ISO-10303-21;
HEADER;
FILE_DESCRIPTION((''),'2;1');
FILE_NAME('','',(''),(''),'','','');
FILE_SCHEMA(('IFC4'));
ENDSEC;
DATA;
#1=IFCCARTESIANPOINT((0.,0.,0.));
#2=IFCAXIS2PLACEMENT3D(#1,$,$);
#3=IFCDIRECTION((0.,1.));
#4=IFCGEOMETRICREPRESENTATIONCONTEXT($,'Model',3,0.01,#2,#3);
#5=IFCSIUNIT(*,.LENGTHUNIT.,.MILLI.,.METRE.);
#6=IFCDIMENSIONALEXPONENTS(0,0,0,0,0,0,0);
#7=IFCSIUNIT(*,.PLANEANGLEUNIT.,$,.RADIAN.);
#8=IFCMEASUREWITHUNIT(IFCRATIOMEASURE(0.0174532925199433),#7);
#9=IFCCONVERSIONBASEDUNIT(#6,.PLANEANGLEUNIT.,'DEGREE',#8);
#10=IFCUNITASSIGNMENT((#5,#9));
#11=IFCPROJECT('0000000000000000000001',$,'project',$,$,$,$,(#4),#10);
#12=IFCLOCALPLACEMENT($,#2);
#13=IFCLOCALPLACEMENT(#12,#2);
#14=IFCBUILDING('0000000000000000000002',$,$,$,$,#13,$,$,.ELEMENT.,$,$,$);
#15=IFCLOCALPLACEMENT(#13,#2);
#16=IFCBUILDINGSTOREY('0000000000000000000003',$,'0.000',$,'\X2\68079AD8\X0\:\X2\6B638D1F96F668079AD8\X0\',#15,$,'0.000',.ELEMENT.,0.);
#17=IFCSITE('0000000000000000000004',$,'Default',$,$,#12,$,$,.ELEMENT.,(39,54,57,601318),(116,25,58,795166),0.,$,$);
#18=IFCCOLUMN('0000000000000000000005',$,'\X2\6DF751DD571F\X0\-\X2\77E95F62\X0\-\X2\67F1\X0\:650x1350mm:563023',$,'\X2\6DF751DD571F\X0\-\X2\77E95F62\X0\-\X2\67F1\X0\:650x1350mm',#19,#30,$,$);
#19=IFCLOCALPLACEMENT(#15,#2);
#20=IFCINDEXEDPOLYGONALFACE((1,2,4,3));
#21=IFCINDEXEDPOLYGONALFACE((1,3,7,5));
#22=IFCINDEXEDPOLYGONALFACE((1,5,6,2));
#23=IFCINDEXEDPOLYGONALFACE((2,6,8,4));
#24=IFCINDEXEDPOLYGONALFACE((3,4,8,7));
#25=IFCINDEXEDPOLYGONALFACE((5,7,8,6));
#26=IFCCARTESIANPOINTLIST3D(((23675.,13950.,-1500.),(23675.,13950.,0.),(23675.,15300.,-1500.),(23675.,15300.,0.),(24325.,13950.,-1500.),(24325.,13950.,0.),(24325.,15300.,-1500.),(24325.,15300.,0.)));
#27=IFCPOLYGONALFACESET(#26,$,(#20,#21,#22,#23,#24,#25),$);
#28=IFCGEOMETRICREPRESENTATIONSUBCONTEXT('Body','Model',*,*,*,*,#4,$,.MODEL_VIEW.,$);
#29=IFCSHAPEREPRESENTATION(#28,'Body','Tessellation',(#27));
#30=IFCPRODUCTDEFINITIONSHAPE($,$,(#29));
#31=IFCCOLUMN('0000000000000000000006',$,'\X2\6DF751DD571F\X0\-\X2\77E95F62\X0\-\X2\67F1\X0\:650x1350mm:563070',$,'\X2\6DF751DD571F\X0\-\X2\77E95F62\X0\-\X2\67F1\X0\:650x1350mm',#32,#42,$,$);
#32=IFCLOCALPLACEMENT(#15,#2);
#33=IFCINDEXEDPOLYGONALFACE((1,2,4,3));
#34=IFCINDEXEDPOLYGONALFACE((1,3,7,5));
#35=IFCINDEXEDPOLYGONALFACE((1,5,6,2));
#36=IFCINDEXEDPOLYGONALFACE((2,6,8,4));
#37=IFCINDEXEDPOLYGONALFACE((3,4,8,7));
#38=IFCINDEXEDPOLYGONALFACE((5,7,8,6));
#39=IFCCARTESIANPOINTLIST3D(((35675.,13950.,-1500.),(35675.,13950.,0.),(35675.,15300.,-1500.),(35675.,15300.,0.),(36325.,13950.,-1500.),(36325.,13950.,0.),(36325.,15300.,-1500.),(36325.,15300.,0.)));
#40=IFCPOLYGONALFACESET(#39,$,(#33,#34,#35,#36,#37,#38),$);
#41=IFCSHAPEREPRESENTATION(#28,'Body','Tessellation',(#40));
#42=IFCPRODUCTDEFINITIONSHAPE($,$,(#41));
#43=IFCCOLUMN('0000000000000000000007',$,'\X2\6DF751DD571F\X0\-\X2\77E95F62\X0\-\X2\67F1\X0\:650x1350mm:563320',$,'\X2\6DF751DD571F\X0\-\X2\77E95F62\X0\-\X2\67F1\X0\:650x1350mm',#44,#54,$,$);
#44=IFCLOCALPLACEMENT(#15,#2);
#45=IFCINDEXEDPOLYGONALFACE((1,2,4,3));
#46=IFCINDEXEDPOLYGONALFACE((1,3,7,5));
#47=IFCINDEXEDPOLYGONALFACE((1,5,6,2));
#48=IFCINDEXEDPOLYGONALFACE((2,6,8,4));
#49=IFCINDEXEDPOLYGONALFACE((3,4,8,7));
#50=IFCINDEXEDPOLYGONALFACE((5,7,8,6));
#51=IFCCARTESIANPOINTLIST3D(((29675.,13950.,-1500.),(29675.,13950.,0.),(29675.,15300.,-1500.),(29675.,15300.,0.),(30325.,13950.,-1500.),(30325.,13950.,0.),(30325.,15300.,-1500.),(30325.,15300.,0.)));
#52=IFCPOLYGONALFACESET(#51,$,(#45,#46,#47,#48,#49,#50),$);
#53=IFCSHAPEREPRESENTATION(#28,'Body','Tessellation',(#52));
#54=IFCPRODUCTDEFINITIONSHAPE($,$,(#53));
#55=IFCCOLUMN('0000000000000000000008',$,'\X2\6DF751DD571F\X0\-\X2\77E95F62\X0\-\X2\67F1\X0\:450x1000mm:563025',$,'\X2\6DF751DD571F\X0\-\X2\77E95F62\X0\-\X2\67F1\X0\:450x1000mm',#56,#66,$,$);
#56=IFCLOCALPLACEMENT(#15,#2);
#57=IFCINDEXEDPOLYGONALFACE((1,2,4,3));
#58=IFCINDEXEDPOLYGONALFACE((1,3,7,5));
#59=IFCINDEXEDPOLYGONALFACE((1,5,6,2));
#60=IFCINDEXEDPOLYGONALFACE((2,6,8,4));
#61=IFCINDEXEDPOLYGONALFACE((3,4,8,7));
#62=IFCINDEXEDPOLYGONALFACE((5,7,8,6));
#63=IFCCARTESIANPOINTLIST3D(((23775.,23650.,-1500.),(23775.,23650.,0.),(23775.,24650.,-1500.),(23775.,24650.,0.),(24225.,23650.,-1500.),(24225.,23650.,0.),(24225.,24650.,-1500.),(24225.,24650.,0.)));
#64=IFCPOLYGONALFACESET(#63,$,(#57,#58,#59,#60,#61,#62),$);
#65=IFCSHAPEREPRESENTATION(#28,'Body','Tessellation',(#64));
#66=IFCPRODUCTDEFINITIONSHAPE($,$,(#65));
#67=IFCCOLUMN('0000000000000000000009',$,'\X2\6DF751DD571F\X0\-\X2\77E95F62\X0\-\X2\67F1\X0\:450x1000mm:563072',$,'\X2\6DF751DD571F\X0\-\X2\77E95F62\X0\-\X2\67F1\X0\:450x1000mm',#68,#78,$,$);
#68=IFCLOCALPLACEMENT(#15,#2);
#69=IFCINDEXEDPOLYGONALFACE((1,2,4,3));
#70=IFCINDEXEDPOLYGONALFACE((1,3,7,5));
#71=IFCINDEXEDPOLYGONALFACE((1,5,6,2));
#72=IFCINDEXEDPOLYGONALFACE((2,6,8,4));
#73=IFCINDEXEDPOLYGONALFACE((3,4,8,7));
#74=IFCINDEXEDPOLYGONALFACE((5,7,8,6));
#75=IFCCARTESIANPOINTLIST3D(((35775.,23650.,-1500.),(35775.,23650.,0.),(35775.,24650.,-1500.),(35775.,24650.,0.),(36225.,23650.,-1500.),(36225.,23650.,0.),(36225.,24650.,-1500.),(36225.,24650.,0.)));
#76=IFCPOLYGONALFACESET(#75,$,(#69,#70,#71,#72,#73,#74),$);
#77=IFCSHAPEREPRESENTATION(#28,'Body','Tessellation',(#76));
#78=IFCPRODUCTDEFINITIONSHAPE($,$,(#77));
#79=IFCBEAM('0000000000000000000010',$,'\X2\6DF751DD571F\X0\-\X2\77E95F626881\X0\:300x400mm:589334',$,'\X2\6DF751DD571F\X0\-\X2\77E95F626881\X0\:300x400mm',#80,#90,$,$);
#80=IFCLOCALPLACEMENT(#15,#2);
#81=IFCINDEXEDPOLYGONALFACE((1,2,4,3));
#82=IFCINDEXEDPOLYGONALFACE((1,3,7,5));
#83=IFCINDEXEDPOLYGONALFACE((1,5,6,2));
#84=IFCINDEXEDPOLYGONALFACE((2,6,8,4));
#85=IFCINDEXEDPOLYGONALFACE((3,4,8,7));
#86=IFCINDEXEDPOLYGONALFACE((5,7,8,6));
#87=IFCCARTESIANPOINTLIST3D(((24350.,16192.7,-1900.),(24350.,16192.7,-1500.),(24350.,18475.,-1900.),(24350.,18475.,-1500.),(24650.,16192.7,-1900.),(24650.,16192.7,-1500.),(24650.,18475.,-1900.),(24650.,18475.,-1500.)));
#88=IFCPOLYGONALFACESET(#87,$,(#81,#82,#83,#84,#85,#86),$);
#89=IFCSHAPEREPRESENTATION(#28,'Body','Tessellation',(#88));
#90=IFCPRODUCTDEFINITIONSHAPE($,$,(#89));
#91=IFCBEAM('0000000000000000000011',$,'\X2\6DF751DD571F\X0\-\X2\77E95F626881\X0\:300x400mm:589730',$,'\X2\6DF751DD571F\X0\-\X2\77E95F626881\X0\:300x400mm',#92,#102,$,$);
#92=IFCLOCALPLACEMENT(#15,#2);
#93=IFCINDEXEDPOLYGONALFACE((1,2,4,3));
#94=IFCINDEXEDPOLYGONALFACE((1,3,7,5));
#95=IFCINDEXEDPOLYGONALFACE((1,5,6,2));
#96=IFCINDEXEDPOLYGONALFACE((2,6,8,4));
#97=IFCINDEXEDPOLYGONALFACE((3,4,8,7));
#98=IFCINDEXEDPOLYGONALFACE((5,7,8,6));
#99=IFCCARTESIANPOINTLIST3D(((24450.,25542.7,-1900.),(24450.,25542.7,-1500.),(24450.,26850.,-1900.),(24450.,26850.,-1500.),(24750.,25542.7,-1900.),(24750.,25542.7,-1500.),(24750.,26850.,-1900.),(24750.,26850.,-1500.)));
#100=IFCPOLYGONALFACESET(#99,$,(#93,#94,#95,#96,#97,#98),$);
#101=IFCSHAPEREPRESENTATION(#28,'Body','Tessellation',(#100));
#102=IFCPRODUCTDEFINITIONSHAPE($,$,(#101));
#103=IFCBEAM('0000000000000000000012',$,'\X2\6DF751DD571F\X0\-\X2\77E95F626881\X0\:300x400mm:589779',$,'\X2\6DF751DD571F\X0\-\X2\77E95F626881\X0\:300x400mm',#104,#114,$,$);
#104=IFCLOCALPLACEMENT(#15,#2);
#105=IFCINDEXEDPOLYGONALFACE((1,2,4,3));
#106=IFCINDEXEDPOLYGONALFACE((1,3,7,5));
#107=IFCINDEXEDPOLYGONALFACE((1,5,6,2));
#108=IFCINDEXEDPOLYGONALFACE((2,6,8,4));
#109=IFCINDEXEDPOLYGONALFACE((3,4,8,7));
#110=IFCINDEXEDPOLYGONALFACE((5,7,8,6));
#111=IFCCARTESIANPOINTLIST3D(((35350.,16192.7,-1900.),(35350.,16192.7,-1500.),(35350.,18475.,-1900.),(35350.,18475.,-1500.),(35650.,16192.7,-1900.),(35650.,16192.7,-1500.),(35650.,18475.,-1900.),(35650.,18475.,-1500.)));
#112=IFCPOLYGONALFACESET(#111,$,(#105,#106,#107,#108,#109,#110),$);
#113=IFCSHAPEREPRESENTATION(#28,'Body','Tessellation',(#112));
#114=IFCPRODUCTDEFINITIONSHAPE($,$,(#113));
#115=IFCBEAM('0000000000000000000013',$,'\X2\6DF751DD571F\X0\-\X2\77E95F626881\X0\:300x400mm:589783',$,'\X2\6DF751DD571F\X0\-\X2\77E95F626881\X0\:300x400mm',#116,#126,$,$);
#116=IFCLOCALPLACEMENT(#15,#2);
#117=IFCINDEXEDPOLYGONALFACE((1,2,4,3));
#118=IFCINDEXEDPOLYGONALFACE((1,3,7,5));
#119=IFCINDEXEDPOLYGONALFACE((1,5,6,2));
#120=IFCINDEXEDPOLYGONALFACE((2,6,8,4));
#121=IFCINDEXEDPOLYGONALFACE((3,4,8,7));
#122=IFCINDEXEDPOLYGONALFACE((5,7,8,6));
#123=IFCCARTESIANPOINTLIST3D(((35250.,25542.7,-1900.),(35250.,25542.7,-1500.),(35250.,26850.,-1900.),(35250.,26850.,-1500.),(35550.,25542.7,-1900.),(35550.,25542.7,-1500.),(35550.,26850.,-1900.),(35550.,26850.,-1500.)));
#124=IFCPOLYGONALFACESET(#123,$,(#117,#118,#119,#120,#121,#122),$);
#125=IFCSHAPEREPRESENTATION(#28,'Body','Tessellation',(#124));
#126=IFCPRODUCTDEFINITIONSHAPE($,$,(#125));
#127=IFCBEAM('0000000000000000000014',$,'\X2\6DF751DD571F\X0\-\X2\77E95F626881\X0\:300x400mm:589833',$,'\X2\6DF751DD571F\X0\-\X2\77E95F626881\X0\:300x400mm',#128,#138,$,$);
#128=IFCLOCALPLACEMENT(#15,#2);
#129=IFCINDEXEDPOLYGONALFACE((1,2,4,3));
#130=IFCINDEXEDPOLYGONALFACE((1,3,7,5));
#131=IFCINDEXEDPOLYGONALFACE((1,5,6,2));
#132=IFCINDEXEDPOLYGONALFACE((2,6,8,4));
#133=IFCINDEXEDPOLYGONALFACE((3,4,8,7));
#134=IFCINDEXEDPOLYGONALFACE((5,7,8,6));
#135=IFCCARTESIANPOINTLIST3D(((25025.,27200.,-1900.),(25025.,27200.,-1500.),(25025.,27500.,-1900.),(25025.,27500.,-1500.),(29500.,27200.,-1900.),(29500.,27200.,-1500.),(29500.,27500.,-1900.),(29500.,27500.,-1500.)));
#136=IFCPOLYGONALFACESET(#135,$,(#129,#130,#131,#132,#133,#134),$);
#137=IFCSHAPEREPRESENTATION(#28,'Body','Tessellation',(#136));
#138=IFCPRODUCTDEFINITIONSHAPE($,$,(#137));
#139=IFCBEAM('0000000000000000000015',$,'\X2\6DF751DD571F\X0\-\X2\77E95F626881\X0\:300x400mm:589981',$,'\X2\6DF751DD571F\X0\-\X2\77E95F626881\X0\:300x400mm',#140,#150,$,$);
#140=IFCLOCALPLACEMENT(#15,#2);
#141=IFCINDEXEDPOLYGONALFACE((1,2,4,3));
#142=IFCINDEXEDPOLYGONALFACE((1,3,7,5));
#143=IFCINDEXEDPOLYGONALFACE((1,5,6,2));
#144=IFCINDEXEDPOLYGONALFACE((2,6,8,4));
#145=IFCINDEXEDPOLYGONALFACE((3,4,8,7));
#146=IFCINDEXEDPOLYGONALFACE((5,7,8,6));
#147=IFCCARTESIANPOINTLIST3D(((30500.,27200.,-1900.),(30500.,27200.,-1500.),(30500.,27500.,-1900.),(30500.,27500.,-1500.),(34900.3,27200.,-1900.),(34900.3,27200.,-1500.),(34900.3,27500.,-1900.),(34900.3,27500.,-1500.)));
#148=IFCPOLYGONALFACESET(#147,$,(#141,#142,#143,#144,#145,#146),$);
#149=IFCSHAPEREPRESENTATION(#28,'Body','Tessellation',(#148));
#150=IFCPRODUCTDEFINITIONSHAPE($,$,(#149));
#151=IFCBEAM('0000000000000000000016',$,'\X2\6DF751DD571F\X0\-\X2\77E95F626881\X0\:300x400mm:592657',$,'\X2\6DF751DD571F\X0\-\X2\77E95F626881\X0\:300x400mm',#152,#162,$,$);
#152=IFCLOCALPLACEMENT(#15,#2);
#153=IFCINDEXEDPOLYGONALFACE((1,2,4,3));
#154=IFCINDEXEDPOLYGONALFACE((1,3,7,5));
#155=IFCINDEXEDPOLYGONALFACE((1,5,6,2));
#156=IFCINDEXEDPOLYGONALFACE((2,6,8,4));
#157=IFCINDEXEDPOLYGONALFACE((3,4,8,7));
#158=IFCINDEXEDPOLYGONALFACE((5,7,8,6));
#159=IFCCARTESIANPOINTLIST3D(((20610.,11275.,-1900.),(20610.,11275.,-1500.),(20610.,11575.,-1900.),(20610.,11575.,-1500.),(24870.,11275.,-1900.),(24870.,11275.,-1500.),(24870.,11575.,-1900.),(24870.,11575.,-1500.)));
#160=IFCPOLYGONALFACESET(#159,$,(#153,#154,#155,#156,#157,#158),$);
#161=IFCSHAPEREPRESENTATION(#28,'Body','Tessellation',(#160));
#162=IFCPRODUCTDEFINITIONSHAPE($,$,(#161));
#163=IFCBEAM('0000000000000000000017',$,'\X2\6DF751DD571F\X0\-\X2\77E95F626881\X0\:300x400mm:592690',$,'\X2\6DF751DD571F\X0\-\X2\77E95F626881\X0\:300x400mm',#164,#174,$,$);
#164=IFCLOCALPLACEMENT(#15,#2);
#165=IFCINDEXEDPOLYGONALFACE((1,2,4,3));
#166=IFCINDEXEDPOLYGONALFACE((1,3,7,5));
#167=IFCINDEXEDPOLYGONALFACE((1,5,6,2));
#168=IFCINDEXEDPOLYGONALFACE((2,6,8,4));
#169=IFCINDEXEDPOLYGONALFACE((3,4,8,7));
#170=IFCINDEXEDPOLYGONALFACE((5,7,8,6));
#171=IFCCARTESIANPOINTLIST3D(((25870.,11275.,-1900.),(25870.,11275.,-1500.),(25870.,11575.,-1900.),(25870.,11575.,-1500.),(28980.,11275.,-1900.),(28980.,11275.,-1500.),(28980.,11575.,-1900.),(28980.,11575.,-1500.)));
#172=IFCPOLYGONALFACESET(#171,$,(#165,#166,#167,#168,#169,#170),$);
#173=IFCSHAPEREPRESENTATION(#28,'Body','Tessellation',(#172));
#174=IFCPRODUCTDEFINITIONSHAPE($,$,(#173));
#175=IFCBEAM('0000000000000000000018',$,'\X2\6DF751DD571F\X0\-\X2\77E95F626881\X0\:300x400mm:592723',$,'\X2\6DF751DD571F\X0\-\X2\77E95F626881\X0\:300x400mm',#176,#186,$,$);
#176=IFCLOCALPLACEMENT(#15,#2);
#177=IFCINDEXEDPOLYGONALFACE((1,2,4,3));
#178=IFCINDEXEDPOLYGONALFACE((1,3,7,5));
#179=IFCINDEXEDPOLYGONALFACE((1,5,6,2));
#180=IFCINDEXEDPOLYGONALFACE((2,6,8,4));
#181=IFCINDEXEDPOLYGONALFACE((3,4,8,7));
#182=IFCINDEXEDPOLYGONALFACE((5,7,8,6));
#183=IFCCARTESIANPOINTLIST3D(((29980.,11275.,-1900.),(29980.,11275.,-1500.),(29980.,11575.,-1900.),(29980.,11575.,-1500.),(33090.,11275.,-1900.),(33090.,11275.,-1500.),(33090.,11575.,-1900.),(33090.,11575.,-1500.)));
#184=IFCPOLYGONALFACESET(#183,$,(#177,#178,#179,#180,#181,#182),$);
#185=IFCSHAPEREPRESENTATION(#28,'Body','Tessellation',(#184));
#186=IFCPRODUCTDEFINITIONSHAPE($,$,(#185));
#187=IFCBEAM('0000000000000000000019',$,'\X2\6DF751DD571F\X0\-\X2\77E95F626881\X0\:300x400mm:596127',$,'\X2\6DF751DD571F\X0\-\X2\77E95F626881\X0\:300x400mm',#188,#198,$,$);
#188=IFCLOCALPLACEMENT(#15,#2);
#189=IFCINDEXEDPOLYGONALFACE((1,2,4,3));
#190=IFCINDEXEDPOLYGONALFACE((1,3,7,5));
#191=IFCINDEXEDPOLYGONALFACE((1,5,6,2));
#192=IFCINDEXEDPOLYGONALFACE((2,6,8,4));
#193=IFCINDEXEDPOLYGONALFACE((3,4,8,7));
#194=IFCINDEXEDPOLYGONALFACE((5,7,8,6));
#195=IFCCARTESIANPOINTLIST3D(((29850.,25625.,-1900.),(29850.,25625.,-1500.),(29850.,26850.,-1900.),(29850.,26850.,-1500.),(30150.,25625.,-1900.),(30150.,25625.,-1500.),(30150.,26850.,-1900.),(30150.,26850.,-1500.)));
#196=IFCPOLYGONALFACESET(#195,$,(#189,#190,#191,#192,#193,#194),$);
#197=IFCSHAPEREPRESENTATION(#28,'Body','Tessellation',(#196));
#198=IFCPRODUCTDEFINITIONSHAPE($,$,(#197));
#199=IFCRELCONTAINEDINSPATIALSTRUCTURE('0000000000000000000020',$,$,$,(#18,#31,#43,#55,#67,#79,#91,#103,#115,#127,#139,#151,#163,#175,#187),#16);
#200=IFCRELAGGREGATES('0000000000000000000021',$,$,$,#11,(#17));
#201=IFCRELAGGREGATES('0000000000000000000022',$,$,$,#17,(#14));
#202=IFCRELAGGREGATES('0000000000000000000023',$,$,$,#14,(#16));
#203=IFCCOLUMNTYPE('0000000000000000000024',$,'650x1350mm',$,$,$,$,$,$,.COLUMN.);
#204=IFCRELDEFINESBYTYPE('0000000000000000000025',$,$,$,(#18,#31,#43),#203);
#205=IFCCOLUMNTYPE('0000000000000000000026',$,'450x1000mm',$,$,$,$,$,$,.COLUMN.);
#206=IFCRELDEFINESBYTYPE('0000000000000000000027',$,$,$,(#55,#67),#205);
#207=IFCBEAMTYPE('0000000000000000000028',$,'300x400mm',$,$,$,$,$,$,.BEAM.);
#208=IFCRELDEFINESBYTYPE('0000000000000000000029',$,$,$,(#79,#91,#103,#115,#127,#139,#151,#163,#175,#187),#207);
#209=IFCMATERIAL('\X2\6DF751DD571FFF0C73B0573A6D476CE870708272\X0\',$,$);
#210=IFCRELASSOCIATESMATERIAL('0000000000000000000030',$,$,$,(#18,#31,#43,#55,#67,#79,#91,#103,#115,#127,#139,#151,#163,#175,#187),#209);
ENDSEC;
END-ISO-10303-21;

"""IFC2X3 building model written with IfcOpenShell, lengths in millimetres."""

from ifc_helpers import new_model, entity, si_unit, converted_unit, direction, frame, frame_2d, origin, origin_2d_with_axis, place, context, subcontext, project, spatial, rectangle, extrude, source, transform, mapped, material, type_object, type_shapes, element, save


model = new_model("IFC2X3")

# Units and contexts
model_context = context("Model", 3, precision=0.01, world=origin(), true_north=direction((0.0, 1.0)))
body_context = subcontext(model_context, "Body", "Model", "MODEL_VIEW")
ifc_project = project(units=[si_unit("LENGTHUNIT", "METRE", prefix="MILLI"), converted_unit("PLANEANGLEUNIT", "DEGREE", entity("IfcRatioMeasure", 0.0174532925199433), si_unit("PLANEANGLEUNIT", "RADIAN"), dimensions=[0, 0, 0, 0, 0, 0, 0])], contexts=[model_context])

# Site, building, storey
site_placement = place(None, origin())
site = spatial("IfcSite", under=ifc_project, at=site_placement, Name="Default", CompositionType="ELEMENT", RefLatitude=(39, 54, 57, 601318), RefLongitude=(116, 25, 58, 795166), RefElevation=0.0)
building_placement = place(site_placement, origin())
building = spatial("IfcBuilding", under=site, at=building_placement, CompositionType="ELEMENT")
storey_placement = place(building_placement, origin())
storey = spatial("IfcBuildingStorey", under=building, at=storey_placement, Name="0.000", ObjectType="标高:正负零标高", LongName="0.000", CompositionType="ELEMENT", Elevation=0.0)

# Columns
ifc_material = material(Name="混凝土，现场浇注灰色")
column_type_1 = type_object("IfcColumnType", Name="650x1350mm", PredefinedType="COLUMN")
shared_shape_1 = source(origin(), body_context, "Body", "SweptSolid", [
    extrude(rectangle(XDim=1350.0, YDim=650.0, at=origin_2d_with_axis()), frame((0.0, 0.0, -1500.0), z_axis=(0.0, 0.0, 1.0), x_axis=(0.0, -1.0, 0.0)), (0.0, 0.0, 1.0), 1500.0),
])
type_shapes(column_type_1, [shared_shape_1])
for number, where, name in (
    (1, (24000.0, 14625.0, 0.0), "混凝土-矩形-柱:650x1350mm:563023"),
    (2, (36000.0, 14625.0, 0.0), "混凝土-矩形-柱:650x1350mm:563070"),
    (3, (30000.0, 14625.0, 0.0), "混凝土-矩形-柱:650x1350mm:563320"),
):
    element("IfcColumn", number, at=place(storey_placement, frame(where)), inside=storey, type_object=column_type_1, material=ifc_material, Name=name, ObjectType="混凝土-矩形-柱:650x1350mm", context=body_context, shape_type="MappedRepresentation", body=[
        mapped(shared_shape_1, transform((0.0, 0.0, 0.0), scale=1.0)),
    ])
column_type_2 = type_object("IfcColumnType", Name="450x1000mm", PredefinedType="COLUMN")
shared_shape_2 = source(origin(), body_context, "Body", "SweptSolid", [
    extrude(rectangle(XDim=1000.0, YDim=450.0, at=origin_2d_with_axis()), frame((0.0, 0.0, -1500.0), z_axis=(0.0, 0.0, 1.0), x_axis=(0.0, -1.0, 0.0)), (0.0, 0.0, 1.0), 1500.0),
])
type_shapes(column_type_2, [shared_shape_2])
for number, where, name in (
    (4, (24000.0, 24150.0, 0.0), "混凝土-矩形-柱:450x1000mm:563025"),
    (5, (36000.0, 24150.0, 0.0), "混凝土-矩形-柱:450x1000mm:563072"),
):
    element("IfcColumn", number, at=place(storey_placement, frame(where)), inside=storey, type_object=column_type_2, material=ifc_material, Name=name, ObjectType="混凝土-矩形-柱:450x1000mm", context=body_context, shape_type="MappedRepresentation", body=[
        mapped(shared_shape_2, transform((0.0, 0.0, 0.0), scale=1.0)),
    ])

# Beams
beam_type_1 = type_object("IfcBeamType", Name="300x400mm", PredefinedType="BEAM")
beam_1_placement = place(storey_placement, frame((24500.0, 18475.0, -1500.0), z_axis=(0.0, 0.0, 1.0), x_axis=(0.0, -1.0, 0.0)))
element("IfcBeam", 6, at=beam_1_placement, inside=storey, type_object=beam_type_1, material=ifc_material, Name="混凝土-矩形梁:300x400mm:589334", ObjectType="混凝土-矩形梁:300x400mm", context=body_context, shape_type="SweptSolid", body=[
    extrude(rectangle(XDim=400.0, YDim=300.0, at=frame_2d((0.0, 0.0), x_axis=(1.0, 0.0))), frame((0.0, 0.0, -200.0), z_axis=(1.0, 0.0, 0.0), x_axis=(0.0, 0.0, -1.0)), (0.0, 0.0, 1.0), 2282.3),
])
beam_2_placement = place(storey_placement, frame((24600.0, 26850.0, -1500.0), z_axis=(0.0, 0.0, 1.0), x_axis=(0.0, -1.0, 0.0)))
element("IfcBeam", 7, at=beam_2_placement, inside=storey, type_object=beam_type_1, material=ifc_material, Name="混凝土-矩形梁:300x400mm:589730", ObjectType="混凝土-矩形梁:300x400mm", context=body_context, shape_type="SweptSolid", body=[
    extrude(rectangle(XDim=400.0, YDim=300.0, at=frame_2d((0.0, 0.0), x_axis=(1.0, 0.0))), frame((0.0, 0.0, -200.0), z_axis=(1.0, 0.0, 0.0), x_axis=(0.0, 0.0, -1.0)), (0.0, 0.0, 1.0), 1307.3),
])
beam_3_placement = place(storey_placement, frame((35500.0, 18475.0, -1500.0), z_axis=(0.0, 0.0, 1.0), x_axis=(0.0, -1.0, 0.0)))
element("IfcBeam", 8, at=beam_3_placement, inside=storey, type_object=beam_type_1, material=ifc_material, Name="混凝土-矩形梁:300x400mm:589779", ObjectType="混凝土-矩形梁:300x400mm", context=body_context, shape_type="SweptSolid", body=[
    extrude(rectangle(XDim=400.0, YDim=300.0, at=frame_2d((0.0, 0.0), x_axis=(1.0, 0.0))), frame((0.0, 0.0, -200.0), z_axis=(1.0, 0.0, 0.0), x_axis=(0.0, 0.0, -1.0)), (0.0, 0.0, 1.0), 2282.3),
])
beam_4_placement = place(storey_placement, frame((35400.0, 26850.0, -1500.0), z_axis=(0.0, 0.0, 1.0), x_axis=(0.0, -1.0, 0.0)))
element("IfcBeam", 9, at=beam_4_placement, inside=storey, type_object=beam_type_1, material=ifc_material, Name="混凝土-矩形梁:300x400mm:589783", ObjectType="混凝土-矩形梁:300x400mm", context=body_context, shape_type="SweptSolid", body=[
    extrude(rectangle(XDim=400.0, YDim=300.0, at=frame_2d((0.0, 0.0), x_axis=(1.0, 0.0))), frame((0.0, 0.0, -200.0), z_axis=(1.0, 0.0, 0.0), x_axis=(0.0, 0.0, -1.0)), (0.0, 0.0, 1.0), 1307.3),
])
beam_5_placement = place(storey_placement, frame((25025.0, 27350.0, -1500.0)))
element("IfcBeam", 10, at=beam_5_placement, inside=storey, type_object=beam_type_1, material=ifc_material, Name="混凝土-矩形梁:300x400mm:589833", ObjectType="混凝土-矩形梁:300x400mm", context=body_context, shape_type="SweptSolid", body=[
    extrude(rectangle(XDim=400.0, YDim=300.0, at=frame_2d((0.0, 0.0), x_axis=(1.0, 0.0))), frame((0.0, 0.0, -200.0), z_axis=(1.0, 0.0, 0.0), x_axis=(0.0, 0.0, -1.0)), (0.0, 0.0, 1.0), 4475.0),
])
beam_6_placement = place(storey_placement, frame((30500.0, 27350.0, -1500.0)))
element("IfcBeam", 11, at=beam_6_placement, inside=storey, type_object=beam_type_1, material=ifc_material, Name="混凝土-矩形梁:300x400mm:589981", ObjectType="混凝土-矩形梁:300x400mm", context=body_context, shape_type="SweptSolid", body=[
    extrude(rectangle(XDim=400.0, YDim=300.0, at=frame_2d((0.0, 0.0), x_axis=(1.0, 0.0))), frame((0.0, 0.0, -200.0), z_axis=(1.0, 0.0, 0.0), x_axis=(0.0, 0.0, -1.0)), (0.0, 0.0, 1.0), 4400.3),
])
beam_7_placement = place(storey_placement, frame((24870.0, 11425.0, -1500.0), z_axis=(0.0, 0.0, 1.0), x_axis=(-1.0, 0.0, 0.0)))
element("IfcBeam", 12, at=beam_7_placement, inside=storey, type_object=beam_type_1, material=ifc_material, Name="混凝土-矩形梁:300x400mm:592657", ObjectType="混凝土-矩形梁:300x400mm", context=body_context, shape_type="SweptSolid", body=[
    extrude(rectangle(XDim=400.0, YDim=300.0, at=frame_2d((0.0, 0.0), x_axis=(1.0, 0.0))), frame((0.0, 0.0, -200.0), z_axis=(1.0, 0.0, 0.0), x_axis=(0.0, 0.0, -1.0)), (0.0, 0.0, 1.0), 4260.0),
])
for number, where, z_axis, x_axis, name in (
    (13, (28980.0, 11425.0, -1500.0), (0.0, 0.0, 1.0), (-1.0, 0.0, 0.0), "混凝土-矩形梁:300x400mm:592690"),
    (14, (33090.0, 11425.0, -1500.0), (0.0, 0.0, 1.0), (-1.0, 0.0, 0.0), "混凝土-矩形梁:300x400mm:592723"),
):
    element("IfcBeam", number, at=place(storey_placement, frame(where, z_axis=z_axis, x_axis=x_axis)), inside=storey, type_object=beam_type_1, material=ifc_material, Name=name, ObjectType="混凝土-矩形梁:300x400mm", context=body_context, shape_type="SweptSolid", body=[
        extrude(rectangle(XDim=400.0, YDim=300.0, at=frame_2d((0.0, 0.0), x_axis=(1.0, 0.0))), frame((0.0, 0.0, -200.0), z_axis=(1.0, 0.0, 0.0), x_axis=(0.0, 0.0, -1.0)), (0.0, 0.0, 1.0), 3110.0),
    ])
beam_8_placement = place(storey_placement, frame((30000.0, 26850.0, -1500.0), z_axis=(0.0, 0.0, 1.0), x_axis=(0.0, -1.0, 0.0)))
element("IfcBeam", 15, at=beam_8_placement, inside=storey, type_object=beam_type_1, material=ifc_material, Name="混凝土-矩形梁:300x400mm:596127", ObjectType="混凝土-矩形梁:300x400mm", context=body_context, shape_type="SweptSolid", body=[
    extrude(rectangle(XDim=400.0, YDim=300.0, at=frame_2d((0.0, 0.0), x_axis=(1.0, 0.0))), frame((0.0, 0.0, -200.0), z_axis=(1.0, 0.0, 0.0), x_axis=(0.0, 0.0, -1.0)), (0.0, 0.0, 1.0), 1225.0),
])

save(model, "model.ifc")
